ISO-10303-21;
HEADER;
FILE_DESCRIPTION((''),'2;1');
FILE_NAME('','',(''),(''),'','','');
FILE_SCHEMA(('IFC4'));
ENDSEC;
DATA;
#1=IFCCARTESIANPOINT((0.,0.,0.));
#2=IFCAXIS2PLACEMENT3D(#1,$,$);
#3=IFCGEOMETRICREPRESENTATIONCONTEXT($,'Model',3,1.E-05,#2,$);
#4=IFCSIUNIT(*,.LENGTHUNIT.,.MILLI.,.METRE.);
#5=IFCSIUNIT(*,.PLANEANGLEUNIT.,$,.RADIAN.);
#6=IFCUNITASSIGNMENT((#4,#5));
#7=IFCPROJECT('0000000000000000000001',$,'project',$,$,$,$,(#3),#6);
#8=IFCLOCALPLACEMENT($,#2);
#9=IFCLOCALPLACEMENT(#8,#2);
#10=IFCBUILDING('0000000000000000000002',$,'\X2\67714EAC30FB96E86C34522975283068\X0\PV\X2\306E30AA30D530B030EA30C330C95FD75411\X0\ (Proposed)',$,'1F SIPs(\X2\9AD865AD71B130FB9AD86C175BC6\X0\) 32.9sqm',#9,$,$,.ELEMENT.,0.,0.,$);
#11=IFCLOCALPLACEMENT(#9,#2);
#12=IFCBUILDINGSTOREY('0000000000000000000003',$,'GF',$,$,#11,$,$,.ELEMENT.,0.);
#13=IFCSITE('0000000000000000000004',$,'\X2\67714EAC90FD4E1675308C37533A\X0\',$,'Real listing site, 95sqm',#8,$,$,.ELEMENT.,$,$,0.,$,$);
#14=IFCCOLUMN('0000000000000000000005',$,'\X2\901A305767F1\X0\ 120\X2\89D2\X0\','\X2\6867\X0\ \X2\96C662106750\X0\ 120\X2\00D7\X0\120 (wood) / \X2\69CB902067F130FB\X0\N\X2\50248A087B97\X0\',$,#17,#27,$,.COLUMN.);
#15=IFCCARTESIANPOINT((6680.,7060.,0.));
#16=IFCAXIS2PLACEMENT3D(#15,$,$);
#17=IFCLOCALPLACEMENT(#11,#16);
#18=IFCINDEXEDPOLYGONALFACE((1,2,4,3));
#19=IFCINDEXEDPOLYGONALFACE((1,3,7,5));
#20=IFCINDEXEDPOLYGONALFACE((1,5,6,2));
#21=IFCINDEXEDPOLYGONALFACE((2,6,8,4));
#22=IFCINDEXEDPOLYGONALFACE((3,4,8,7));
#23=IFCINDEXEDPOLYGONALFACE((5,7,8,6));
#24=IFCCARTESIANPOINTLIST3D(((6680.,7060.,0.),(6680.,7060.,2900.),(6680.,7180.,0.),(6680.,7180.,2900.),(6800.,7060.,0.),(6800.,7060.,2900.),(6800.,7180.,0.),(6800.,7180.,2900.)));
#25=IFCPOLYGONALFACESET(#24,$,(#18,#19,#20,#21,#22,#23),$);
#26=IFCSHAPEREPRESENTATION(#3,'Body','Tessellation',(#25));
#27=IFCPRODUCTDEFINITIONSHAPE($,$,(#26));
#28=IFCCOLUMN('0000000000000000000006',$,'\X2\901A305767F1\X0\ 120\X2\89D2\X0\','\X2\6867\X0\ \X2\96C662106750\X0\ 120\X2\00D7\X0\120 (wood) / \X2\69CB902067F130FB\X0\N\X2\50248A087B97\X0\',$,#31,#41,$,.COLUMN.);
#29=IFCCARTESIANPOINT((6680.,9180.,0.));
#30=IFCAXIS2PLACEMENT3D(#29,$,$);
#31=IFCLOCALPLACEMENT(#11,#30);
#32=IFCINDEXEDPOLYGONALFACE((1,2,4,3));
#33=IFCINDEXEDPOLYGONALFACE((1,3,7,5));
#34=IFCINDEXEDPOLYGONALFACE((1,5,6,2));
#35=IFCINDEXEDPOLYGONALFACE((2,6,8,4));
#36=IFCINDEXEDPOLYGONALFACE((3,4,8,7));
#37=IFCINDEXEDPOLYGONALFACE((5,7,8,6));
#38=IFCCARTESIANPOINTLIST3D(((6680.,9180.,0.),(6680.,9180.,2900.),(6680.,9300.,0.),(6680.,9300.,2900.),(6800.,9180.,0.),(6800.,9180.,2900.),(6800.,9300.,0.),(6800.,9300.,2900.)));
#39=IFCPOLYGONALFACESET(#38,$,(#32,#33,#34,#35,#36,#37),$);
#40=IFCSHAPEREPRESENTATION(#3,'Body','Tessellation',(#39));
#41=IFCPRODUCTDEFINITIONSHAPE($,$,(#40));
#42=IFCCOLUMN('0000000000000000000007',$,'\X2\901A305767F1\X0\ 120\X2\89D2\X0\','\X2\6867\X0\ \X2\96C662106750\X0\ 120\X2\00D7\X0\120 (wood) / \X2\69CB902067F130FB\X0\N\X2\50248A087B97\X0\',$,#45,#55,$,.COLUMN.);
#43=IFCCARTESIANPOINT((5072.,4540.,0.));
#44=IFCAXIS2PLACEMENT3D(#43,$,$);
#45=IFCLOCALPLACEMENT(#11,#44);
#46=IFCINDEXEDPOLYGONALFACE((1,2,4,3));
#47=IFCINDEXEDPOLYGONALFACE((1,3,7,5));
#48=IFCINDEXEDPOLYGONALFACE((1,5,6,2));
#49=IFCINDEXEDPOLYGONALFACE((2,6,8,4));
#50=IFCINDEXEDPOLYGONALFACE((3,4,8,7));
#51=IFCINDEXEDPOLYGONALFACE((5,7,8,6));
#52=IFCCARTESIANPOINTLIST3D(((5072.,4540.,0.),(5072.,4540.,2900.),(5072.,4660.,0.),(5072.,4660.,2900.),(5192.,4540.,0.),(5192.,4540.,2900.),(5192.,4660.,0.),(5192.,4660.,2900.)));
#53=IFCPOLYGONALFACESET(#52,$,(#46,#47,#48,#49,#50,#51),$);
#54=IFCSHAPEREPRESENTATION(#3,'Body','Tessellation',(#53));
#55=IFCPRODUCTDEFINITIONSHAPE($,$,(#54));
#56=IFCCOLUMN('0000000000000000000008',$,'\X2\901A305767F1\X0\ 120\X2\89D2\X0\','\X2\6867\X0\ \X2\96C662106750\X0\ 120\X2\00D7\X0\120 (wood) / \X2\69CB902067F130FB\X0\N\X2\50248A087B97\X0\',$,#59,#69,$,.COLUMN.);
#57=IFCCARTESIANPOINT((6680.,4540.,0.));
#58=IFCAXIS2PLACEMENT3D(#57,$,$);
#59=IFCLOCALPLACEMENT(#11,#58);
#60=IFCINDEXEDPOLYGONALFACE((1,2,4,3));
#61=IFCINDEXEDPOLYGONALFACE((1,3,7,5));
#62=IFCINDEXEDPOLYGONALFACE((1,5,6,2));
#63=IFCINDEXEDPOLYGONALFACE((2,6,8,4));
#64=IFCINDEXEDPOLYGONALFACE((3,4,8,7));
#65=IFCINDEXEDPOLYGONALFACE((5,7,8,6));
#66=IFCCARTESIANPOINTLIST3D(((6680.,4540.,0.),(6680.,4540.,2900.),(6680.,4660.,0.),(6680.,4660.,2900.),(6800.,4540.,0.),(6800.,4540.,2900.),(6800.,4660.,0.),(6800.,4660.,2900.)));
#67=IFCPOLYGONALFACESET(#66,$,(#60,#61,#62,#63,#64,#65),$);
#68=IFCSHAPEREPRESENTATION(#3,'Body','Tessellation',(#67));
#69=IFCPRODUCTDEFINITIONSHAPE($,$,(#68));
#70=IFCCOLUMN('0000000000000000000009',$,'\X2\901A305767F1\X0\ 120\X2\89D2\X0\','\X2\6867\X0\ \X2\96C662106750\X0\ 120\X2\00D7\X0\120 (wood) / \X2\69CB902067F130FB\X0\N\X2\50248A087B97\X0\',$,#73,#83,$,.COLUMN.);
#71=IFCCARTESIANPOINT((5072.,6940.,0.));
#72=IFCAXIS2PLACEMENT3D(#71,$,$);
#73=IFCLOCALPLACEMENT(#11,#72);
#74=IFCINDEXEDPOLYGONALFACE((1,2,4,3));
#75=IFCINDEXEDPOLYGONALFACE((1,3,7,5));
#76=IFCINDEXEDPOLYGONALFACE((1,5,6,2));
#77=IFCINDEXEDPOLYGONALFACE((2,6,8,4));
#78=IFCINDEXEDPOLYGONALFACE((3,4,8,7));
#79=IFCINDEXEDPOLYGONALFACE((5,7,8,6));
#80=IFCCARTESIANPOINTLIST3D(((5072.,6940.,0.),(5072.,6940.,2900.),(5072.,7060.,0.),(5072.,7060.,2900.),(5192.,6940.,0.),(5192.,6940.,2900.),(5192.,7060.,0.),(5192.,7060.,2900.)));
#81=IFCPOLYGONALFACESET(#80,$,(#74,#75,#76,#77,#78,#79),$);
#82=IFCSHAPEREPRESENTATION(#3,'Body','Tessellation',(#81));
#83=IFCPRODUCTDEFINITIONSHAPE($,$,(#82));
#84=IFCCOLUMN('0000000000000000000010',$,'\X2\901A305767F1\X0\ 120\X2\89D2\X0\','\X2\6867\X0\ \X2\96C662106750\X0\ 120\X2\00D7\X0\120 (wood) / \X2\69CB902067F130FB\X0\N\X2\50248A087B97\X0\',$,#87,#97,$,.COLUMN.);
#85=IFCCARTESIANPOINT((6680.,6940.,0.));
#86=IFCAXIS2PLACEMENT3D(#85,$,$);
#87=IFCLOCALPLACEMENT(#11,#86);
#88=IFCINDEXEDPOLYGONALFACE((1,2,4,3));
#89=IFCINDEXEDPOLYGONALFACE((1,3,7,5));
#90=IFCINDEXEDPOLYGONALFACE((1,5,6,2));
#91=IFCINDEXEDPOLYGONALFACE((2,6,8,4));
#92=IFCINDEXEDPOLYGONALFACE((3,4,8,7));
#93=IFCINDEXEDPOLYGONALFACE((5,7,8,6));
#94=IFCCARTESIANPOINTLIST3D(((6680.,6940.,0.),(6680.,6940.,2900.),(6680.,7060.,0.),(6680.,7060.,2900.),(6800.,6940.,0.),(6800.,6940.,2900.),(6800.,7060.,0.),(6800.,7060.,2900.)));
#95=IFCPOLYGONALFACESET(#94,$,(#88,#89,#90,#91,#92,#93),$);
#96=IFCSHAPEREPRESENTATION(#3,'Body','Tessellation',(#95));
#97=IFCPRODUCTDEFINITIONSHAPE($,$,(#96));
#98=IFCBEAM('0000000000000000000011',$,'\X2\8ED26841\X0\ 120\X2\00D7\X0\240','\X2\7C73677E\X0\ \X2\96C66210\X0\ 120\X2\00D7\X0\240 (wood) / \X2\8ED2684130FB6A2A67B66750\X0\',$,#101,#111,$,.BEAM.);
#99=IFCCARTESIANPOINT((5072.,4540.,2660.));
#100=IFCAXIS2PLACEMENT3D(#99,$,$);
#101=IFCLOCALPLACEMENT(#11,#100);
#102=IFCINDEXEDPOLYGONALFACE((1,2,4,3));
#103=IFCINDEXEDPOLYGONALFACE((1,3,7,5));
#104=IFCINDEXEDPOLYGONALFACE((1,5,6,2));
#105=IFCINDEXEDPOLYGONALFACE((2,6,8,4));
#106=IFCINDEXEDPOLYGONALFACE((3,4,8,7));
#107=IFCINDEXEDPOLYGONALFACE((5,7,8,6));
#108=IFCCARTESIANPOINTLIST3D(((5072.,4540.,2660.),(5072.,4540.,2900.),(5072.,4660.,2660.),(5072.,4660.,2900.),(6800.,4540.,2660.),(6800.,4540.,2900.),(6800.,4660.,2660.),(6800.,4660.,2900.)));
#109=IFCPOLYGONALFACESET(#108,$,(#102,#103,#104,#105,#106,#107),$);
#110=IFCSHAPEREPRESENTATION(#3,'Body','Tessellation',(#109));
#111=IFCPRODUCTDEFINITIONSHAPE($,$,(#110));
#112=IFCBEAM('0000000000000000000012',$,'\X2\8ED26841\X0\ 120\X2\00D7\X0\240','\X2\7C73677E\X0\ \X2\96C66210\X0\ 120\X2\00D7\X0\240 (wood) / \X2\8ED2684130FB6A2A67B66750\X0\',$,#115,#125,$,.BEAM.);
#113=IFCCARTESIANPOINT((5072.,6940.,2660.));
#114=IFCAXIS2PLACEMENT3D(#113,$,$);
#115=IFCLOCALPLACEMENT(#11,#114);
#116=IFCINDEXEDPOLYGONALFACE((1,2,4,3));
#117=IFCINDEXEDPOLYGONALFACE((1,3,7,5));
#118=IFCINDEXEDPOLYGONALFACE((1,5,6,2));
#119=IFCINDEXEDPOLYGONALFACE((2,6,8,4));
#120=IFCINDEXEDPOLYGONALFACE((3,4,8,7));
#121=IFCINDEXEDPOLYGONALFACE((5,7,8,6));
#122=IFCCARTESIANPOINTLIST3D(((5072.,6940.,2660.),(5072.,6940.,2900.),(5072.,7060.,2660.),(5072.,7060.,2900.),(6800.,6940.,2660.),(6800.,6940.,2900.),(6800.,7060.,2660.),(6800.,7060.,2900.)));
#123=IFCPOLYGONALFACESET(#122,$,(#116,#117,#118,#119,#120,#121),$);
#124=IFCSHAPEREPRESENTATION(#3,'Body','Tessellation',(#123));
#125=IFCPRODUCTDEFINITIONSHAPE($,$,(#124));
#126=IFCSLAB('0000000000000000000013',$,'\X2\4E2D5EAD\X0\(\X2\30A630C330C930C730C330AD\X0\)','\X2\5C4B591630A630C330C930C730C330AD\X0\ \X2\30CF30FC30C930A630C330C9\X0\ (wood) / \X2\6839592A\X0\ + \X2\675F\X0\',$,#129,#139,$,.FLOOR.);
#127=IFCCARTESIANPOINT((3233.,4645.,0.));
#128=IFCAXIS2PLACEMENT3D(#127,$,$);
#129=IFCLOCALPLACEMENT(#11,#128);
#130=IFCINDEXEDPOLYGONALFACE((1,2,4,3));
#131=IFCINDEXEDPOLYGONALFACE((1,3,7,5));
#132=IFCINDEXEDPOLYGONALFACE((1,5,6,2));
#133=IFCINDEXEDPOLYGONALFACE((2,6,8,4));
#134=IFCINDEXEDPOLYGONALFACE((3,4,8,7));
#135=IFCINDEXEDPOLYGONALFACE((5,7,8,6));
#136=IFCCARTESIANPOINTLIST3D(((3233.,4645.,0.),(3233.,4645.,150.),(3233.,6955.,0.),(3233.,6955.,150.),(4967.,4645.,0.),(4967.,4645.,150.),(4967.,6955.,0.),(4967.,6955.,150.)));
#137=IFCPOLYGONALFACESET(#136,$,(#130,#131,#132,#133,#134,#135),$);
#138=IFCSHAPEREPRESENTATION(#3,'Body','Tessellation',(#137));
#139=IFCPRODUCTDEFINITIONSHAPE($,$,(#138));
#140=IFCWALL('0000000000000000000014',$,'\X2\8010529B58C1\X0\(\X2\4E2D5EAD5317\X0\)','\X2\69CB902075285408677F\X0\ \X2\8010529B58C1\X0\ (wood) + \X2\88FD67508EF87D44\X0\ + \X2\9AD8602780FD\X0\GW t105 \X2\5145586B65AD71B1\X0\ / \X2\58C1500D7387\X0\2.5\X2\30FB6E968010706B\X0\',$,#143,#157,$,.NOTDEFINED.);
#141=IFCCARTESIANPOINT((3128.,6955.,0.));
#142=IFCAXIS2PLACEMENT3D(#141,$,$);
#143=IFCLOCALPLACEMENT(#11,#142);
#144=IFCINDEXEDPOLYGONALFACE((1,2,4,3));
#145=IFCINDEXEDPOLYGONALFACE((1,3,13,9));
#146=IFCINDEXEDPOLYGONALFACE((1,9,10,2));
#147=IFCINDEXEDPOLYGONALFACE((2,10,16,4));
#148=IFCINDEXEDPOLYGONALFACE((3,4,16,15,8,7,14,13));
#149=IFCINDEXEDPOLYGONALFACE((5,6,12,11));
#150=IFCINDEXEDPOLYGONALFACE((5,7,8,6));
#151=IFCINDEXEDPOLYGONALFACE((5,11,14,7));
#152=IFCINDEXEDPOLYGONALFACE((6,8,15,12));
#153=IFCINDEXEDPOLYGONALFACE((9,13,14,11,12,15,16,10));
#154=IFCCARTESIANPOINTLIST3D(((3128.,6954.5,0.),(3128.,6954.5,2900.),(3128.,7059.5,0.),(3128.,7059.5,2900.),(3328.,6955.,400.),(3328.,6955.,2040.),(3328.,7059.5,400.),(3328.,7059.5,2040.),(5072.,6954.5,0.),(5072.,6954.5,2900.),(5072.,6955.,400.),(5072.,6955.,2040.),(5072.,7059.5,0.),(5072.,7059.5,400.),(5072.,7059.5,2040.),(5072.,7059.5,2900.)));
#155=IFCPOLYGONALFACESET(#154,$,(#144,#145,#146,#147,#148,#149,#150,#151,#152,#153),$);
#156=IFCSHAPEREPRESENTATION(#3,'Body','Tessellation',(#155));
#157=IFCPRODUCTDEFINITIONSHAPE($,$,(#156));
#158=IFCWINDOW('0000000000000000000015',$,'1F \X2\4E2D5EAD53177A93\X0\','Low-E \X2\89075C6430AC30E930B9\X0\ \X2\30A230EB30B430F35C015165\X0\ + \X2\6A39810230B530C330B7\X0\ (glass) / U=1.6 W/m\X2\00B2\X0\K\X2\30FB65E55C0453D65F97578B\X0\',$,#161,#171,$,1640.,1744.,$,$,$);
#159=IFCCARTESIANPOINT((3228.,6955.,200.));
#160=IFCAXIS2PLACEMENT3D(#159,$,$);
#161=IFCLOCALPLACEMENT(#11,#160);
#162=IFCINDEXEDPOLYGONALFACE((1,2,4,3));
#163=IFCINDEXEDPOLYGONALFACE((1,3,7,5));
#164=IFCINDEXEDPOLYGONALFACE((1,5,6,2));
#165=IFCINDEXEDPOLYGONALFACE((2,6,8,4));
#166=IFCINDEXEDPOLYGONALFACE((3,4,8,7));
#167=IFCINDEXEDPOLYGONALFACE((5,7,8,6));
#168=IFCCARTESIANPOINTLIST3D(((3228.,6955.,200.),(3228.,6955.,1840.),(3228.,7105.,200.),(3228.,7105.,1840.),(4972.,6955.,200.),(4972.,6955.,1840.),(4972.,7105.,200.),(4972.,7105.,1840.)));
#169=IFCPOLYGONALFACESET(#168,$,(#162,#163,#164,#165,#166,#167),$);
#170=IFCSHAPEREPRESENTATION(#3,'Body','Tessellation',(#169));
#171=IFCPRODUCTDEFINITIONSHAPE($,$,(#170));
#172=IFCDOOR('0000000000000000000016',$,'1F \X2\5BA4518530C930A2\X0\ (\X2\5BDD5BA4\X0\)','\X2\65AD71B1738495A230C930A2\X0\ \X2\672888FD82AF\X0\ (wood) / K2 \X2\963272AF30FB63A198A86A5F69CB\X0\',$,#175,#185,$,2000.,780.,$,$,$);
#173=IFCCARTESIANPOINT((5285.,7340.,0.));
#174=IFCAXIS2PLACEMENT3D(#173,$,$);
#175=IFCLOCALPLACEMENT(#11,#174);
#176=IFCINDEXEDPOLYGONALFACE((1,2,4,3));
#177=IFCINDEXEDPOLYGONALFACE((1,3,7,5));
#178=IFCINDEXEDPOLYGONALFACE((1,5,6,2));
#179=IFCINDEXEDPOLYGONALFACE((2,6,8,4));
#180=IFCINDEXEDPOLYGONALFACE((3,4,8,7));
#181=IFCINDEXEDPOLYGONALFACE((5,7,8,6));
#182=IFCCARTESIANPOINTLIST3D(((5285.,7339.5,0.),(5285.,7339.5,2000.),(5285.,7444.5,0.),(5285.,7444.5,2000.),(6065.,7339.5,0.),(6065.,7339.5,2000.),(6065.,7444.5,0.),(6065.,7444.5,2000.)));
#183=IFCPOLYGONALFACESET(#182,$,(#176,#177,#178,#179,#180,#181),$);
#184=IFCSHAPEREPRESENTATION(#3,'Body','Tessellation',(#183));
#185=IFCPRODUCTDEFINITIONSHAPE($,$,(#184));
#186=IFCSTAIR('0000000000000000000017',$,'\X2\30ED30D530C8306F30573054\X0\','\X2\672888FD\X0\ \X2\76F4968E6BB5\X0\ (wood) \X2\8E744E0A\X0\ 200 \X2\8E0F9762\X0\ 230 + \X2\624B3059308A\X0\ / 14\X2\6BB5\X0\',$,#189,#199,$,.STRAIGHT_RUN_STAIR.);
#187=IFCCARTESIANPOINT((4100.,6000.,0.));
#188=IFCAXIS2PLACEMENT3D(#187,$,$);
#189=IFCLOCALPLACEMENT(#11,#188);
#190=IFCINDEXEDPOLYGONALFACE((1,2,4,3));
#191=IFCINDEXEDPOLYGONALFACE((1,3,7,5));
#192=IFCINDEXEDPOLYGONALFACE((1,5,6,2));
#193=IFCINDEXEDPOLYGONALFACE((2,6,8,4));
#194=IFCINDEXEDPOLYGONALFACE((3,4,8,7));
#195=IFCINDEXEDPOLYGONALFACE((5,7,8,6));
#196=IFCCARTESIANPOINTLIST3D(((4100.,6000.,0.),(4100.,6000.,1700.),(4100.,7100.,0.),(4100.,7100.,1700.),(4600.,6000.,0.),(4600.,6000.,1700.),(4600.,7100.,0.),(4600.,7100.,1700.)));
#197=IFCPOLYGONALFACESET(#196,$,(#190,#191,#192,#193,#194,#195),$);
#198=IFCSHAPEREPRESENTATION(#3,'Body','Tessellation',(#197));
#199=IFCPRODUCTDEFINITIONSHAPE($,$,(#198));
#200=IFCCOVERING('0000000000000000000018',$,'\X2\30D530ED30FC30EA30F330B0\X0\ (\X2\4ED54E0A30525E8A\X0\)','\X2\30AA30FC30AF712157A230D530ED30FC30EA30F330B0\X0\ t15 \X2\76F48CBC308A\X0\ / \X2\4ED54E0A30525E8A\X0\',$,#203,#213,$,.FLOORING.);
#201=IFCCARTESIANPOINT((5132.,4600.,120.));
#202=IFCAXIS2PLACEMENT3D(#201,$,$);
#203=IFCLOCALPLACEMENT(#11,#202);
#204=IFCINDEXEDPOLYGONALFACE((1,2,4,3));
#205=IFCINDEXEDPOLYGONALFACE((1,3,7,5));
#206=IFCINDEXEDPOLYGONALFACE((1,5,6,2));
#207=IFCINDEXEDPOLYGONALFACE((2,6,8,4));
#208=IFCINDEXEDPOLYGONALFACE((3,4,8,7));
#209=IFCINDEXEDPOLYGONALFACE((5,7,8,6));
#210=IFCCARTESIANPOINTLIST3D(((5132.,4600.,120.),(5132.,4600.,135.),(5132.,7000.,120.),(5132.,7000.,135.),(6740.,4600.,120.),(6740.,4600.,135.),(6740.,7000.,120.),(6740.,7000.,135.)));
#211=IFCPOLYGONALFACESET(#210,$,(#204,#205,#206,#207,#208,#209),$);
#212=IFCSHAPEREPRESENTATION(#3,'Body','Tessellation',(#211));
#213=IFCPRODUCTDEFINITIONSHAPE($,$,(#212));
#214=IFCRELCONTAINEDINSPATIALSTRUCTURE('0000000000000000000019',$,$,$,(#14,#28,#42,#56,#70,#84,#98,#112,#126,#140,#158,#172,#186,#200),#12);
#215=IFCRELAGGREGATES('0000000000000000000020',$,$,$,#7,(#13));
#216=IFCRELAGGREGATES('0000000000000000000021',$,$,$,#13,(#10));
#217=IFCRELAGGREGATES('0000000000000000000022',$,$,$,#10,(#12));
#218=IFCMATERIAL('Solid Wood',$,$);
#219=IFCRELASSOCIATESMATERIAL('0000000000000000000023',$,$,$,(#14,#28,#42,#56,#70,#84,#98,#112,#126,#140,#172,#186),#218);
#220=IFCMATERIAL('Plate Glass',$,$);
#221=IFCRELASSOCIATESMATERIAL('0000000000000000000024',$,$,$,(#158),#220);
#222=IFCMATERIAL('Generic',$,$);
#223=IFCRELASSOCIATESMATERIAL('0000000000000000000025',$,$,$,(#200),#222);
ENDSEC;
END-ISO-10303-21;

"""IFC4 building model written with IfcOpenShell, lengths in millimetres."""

from ifc_helpers import new_model, si_unit, frame, frame_2d, origin, place, context, project, spatial, rectangle, extrude, material, element, fill, save


model = new_model("IFC4")

# Units and contexts
model_context = context("Model", 3, precision=1e-05, world=origin())
ifc_project = project(units=[si_unit("LENGTHUNIT", "METRE", prefix="MILLI"), si_unit("PLANEANGLEUNIT", "RADIAN")], contexts=[model_context])

# Site, building, storey
site_placement = place(None, origin())
site = spatial("IfcSite", under=ifc_project, at=site_placement, Name="東京都世田谷区", ObjectType="Real listing site, 95sqm", CompositionType="ELEMENT", RefElevation=0.0)
building_placement = place(site_placement, origin())
building = spatial("IfcBuilding", under=site, at=building_placement, Name="東京・雨水利用とPVのオフグリッド志向 (Proposed)", ObjectType="1F SIPs(高断熱・高気密) 32.9sqm", CompositionType="ELEMENT", ElevationOfRefHeight=0.0, ElevationOfTerrain=0.0)
storey_placement = place(building_placement, origin())
storey = spatial("IfcBuildingStorey", under=building, at=storey_placement, Name="GF", CompositionType="ELEMENT", Elevation=0.0)

# Columns
ifc_material_1 = material(Name="Solid Wood")
column_1_placement = place(storey_placement, frame((6680.0, 7060.0, 0.0)))
element("IfcColumn", 1, at=column_1_placement, inside=storey, material=ifc_material_1, Name="通し柱 120角", Description="桧 集成材 120×120 (wood) / 構造柱・N値計算", PredefinedType="COLUMN", context=model_context, shape_type="SweptSolid", body=[
    extrude(rectangle(XDim=120.0, YDim=120.0, at=frame_2d((60.0, 60.0))), frame((6680.0, 7060.0, 0.0)), (0.0, 0.0, 1.0), 2900.0),
])
column_2_placement = place(storey_placement, frame((6680.0, 9180.0, 0.0)))
element("IfcColumn", 2, at=column_2_placement, inside=storey, material=ifc_material_1, Name="通し柱 120角", Description="桧 集成材 120×120 (wood) / 構造柱・N値計算", PredefinedType="COLUMN", context=model_context, shape_type="SweptSolid", body=[
    extrude(rectangle(XDim=120.0, YDim=120.0, at=frame_2d((60.0, 60.0))), frame((6680.0, 9180.0, 0.0)), (0.0, 0.0, 1.0), 2900.0),
])
column_3_placement = place(storey_placement, frame((5072.0, 4540.0, 0.0)))
element("IfcColumn", 3, at=column_3_placement, inside=storey, material=ifc_material_1, Name="通し柱 120角", Description="桧 集成材 120×120 (wood) / 構造柱・N値計算", PredefinedType="COLUMN", context=model_context, shape_type="SweptSolid", body=[
    extrude(rectangle(XDim=120.0, YDim=120.0, at=frame_2d((60.0, 60.0))), frame((5072.0, 4540.0, 0.0)), (0.0, 0.0, 1.0), 2900.0),
])
column_4_placement = place(storey_placement, frame((6680.0, 4540.0, 0.0)))
element("IfcColumn", 4, at=column_4_placement, inside=storey, material=ifc_material_1, Name="通し柱 120角", Description="桧 集成材 120×120 (wood) / 構造柱・N値計算", PredefinedType="COLUMN", context=model_context, shape_type="SweptSolid", body=[
    extrude(rectangle(XDim=120.0, YDim=120.0, at=frame_2d((60.0, 60.0))), frame((6680.0, 4540.0, 0.0)), (0.0, 0.0, 1.0), 2900.0),
])
column_5_placement = place(storey_placement, frame((5072.0, 6940.0, 0.0)))
element("IfcColumn", 5, at=column_5_placement, inside=storey, material=ifc_material_1, Name="通し柱 120角", Description="桧 集成材 120×120 (wood) / 構造柱・N値計算", PredefinedType="COLUMN", context=model_context, shape_type="SweptSolid", body=[
    extrude(rectangle(XDim=120.0, YDim=120.0, at=frame_2d((60.0, 60.0))), frame((5072.0, 6940.0, 0.0)), (0.0, 0.0, 1.0), 2900.0),
])
column_6_placement = place(storey_placement, frame((6680.0, 6940.0, 0.0)))
element("IfcColumn", 6, at=column_6_placement, inside=storey, material=ifc_material_1, Name="通し柱 120角", Description="桧 集成材 120×120 (wood) / 構造柱・N値計算", PredefinedType="COLUMN", context=model_context, shape_type="SweptSolid", body=[
    extrude(rectangle(XDim=120.0, YDim=120.0, at=frame_2d((60.0, 60.0))), frame((6680.0, 6940.0, 0.0)), (0.0, 0.0, 1.0), 2900.0),
])

# Beams
beam_1_placement = place(storey_placement, frame((5072.0, 4540.0, 2660.0)))
element("IfcBeam", 7, at=beam_1_placement, inside=storey, material=ifc_material_1, Name="軒桁 120×240", Description="米松 集成 120×240 (wood) / 軒桁・横架材", PredefinedType="BEAM", context=model_context, shape_type="SweptSolid", body=[
    extrude(rectangle(XDim=1728.0, YDim=120.0, at=frame_2d((864.0, 60.0))), frame((5072.0, 4540.0, 2660.0)), (0.0, 0.0, 1.0), 240.0),
])
beam_2_placement = place(storey_placement, frame((5072.0, 6940.0, 2660.0)))
element("IfcBeam", 8, at=beam_2_placement, inside=storey, material=ifc_material_1, Name="軒桁 120×240", Description="米松 集成 120×240 (wood) / 軒桁・横架材", PredefinedType="BEAM", context=model_context, shape_type="SweptSolid", body=[
    extrude(rectangle(XDim=1728.0, YDim=120.0, at=frame_2d((864.0, 60.0))), frame((5072.0, 6940.0, 2660.0)), (0.0, 0.0, 1.0), 240.0),
])

# Slab
slab_placement = place(storey_placement, frame((3233.0, 4645.0, 0.0)))
element("IfcSlab", 9, at=slab_placement, inside=storey, material=ifc_material_1, Name="中庭(ウッドデッキ)", Description="屋外ウッドデッキ ハードウッド (wood) / 根太 + 束", PredefinedType="FLOOR", context=model_context, shape_type="SweptSolid", body=[
    extrude(rectangle(XDim=1734.0, YDim=2310.0, at=frame_2d((867.0, 1155.0))), frame((3233.0, 4645.0, 0.0)), (0.0, 0.0, 1.0), 150.0),
])

# Wall, opening, window
wall_1_placement = place(storey_placement, frame((3128.0, 6955.0, 0.0)))
wall_1 = element("IfcWall", 10, at=wall_1_placement, inside=storey, material=ifc_material_1, Name="耐力壁(中庭北)", Description="構造用合板 耐力壁 (wood) + 製材軸組 + 高性能GW t105 充填断熱 / 壁倍率2.5・準耐火", PredefinedType="NOTDEFINED", context=model_context, shape_type="SweptSolid", body=[
    extrude(rectangle(XDim=1944.0, YDim=105.0, at=frame_2d((972.0, 52.0))), frame((3128.0, 6955.0, 0.0)), (0.0, 0.0, 1.0), 2900.0),
])
opening_placement = place(storey_placement, frame((3228.0, 6955.0, 200.0)))
opening = element("IfcOpeningElement", 11, at=opening_placement, cuts=wall_1, PredefinedType="NOTDEFINED", context=model_context, shape_type="SweptSolid", body=[
    extrude(rectangle(XDim=1744.0, YDim=150.0, at=frame_2d((872.0, 75.0))), frame((3228.0, 6955.0, 200.0)), (0.0, 0.0, 1.0), 1640.0),
])
ifc_material_2 = material(Name="Plate Glass")
window_placement = place(storey_placement, frame((3228.0, 6955.0, 200.0)))
window = element("IfcWindow", 12, at=window_placement, inside=storey, material=ifc_material_2, Name="1F 中庭北窓", Description="Low-E 複層ガラス アルゴン封入 + 樹脂サッシ (glass) / U=1.6 W/m²K・日射取得型", OverallHeight=1640.0, OverallWidth=1744.0, context=model_context, shape_type="SweptSolid", body=[
    extrude(rectangle(XDim=1744.0, YDim=150.0, at=frame_2d((872.0, 75.0))), frame((3228.0, 6955.0, 200.0)), (0.0, 0.0, 1.0), 1640.0),
])
fill(opening, window)

# Door
door_placement = place(storey_placement, frame((5285.0, 7340.0, 0.0)))
element("IfcDoor", 13, at=door_placement, inside=storey, material=ifc_material_1, Name="1F 室内ドア (寝室)", Description="断熱玄関ドア 木製芯 (wood) / K2 防犯・採風機構", OverallHeight=2000.0, OverallWidth=780.0, context=model_context, shape_type="SweptSolid", body=[
    extrude(rectangle(XDim=780.0, YDim=105.0, at=frame_2d((390.0, 52.0))), frame((5285.0, 7340.0, 0.0)), (0.0, 0.0, 1.0), 2000.0),
])

# Stair
stair_placement = place(storey_placement, frame((4100.0, 6000.0, 0.0)))
element("IfcStair", 14, at=stair_placement, inside=storey, material=ifc_material_1, Name="ロフトはしご", Description="木製 直階段 (wood) 蹴上 200 踏面 230 + 手すり / 14段", PredefinedType="STRAIGHT_RUN_STAIR", context=model_context, shape_type="SweptSolid", body=[
    extrude(rectangle(XDim=500.0, YDim=1100.0, at=frame_2d((250.0, 550.0))), frame((4100.0, 6000.0, 0.0)), (0.0, 0.0, 1.0), 1700.0),
])

# Covering
ifc_material_3 = material(Name="Generic")
covering_placement = place(storey_placement, frame((5132.0, 4600.0, 120.0)))
element("IfcCovering", 15, at=covering_placement, inside=storey, material=ifc_material_3, Name="フローリング (仕上げ床)", Description="オーク無垢フローリング t15 直貼り / 仕上げ床", PredefinedType="FLOORING", context=model_context, shape_type="SweptSolid", body=[
    extrude(rectangle(XDim=1608.0, YDim=2400.0, at=frame_2d((804.0, 1200.0))), frame((5132.0, 4600.0, 120.0)), (0.0, 0.0, 1.0), 15.0),
])

save(model, "model.ifc")
